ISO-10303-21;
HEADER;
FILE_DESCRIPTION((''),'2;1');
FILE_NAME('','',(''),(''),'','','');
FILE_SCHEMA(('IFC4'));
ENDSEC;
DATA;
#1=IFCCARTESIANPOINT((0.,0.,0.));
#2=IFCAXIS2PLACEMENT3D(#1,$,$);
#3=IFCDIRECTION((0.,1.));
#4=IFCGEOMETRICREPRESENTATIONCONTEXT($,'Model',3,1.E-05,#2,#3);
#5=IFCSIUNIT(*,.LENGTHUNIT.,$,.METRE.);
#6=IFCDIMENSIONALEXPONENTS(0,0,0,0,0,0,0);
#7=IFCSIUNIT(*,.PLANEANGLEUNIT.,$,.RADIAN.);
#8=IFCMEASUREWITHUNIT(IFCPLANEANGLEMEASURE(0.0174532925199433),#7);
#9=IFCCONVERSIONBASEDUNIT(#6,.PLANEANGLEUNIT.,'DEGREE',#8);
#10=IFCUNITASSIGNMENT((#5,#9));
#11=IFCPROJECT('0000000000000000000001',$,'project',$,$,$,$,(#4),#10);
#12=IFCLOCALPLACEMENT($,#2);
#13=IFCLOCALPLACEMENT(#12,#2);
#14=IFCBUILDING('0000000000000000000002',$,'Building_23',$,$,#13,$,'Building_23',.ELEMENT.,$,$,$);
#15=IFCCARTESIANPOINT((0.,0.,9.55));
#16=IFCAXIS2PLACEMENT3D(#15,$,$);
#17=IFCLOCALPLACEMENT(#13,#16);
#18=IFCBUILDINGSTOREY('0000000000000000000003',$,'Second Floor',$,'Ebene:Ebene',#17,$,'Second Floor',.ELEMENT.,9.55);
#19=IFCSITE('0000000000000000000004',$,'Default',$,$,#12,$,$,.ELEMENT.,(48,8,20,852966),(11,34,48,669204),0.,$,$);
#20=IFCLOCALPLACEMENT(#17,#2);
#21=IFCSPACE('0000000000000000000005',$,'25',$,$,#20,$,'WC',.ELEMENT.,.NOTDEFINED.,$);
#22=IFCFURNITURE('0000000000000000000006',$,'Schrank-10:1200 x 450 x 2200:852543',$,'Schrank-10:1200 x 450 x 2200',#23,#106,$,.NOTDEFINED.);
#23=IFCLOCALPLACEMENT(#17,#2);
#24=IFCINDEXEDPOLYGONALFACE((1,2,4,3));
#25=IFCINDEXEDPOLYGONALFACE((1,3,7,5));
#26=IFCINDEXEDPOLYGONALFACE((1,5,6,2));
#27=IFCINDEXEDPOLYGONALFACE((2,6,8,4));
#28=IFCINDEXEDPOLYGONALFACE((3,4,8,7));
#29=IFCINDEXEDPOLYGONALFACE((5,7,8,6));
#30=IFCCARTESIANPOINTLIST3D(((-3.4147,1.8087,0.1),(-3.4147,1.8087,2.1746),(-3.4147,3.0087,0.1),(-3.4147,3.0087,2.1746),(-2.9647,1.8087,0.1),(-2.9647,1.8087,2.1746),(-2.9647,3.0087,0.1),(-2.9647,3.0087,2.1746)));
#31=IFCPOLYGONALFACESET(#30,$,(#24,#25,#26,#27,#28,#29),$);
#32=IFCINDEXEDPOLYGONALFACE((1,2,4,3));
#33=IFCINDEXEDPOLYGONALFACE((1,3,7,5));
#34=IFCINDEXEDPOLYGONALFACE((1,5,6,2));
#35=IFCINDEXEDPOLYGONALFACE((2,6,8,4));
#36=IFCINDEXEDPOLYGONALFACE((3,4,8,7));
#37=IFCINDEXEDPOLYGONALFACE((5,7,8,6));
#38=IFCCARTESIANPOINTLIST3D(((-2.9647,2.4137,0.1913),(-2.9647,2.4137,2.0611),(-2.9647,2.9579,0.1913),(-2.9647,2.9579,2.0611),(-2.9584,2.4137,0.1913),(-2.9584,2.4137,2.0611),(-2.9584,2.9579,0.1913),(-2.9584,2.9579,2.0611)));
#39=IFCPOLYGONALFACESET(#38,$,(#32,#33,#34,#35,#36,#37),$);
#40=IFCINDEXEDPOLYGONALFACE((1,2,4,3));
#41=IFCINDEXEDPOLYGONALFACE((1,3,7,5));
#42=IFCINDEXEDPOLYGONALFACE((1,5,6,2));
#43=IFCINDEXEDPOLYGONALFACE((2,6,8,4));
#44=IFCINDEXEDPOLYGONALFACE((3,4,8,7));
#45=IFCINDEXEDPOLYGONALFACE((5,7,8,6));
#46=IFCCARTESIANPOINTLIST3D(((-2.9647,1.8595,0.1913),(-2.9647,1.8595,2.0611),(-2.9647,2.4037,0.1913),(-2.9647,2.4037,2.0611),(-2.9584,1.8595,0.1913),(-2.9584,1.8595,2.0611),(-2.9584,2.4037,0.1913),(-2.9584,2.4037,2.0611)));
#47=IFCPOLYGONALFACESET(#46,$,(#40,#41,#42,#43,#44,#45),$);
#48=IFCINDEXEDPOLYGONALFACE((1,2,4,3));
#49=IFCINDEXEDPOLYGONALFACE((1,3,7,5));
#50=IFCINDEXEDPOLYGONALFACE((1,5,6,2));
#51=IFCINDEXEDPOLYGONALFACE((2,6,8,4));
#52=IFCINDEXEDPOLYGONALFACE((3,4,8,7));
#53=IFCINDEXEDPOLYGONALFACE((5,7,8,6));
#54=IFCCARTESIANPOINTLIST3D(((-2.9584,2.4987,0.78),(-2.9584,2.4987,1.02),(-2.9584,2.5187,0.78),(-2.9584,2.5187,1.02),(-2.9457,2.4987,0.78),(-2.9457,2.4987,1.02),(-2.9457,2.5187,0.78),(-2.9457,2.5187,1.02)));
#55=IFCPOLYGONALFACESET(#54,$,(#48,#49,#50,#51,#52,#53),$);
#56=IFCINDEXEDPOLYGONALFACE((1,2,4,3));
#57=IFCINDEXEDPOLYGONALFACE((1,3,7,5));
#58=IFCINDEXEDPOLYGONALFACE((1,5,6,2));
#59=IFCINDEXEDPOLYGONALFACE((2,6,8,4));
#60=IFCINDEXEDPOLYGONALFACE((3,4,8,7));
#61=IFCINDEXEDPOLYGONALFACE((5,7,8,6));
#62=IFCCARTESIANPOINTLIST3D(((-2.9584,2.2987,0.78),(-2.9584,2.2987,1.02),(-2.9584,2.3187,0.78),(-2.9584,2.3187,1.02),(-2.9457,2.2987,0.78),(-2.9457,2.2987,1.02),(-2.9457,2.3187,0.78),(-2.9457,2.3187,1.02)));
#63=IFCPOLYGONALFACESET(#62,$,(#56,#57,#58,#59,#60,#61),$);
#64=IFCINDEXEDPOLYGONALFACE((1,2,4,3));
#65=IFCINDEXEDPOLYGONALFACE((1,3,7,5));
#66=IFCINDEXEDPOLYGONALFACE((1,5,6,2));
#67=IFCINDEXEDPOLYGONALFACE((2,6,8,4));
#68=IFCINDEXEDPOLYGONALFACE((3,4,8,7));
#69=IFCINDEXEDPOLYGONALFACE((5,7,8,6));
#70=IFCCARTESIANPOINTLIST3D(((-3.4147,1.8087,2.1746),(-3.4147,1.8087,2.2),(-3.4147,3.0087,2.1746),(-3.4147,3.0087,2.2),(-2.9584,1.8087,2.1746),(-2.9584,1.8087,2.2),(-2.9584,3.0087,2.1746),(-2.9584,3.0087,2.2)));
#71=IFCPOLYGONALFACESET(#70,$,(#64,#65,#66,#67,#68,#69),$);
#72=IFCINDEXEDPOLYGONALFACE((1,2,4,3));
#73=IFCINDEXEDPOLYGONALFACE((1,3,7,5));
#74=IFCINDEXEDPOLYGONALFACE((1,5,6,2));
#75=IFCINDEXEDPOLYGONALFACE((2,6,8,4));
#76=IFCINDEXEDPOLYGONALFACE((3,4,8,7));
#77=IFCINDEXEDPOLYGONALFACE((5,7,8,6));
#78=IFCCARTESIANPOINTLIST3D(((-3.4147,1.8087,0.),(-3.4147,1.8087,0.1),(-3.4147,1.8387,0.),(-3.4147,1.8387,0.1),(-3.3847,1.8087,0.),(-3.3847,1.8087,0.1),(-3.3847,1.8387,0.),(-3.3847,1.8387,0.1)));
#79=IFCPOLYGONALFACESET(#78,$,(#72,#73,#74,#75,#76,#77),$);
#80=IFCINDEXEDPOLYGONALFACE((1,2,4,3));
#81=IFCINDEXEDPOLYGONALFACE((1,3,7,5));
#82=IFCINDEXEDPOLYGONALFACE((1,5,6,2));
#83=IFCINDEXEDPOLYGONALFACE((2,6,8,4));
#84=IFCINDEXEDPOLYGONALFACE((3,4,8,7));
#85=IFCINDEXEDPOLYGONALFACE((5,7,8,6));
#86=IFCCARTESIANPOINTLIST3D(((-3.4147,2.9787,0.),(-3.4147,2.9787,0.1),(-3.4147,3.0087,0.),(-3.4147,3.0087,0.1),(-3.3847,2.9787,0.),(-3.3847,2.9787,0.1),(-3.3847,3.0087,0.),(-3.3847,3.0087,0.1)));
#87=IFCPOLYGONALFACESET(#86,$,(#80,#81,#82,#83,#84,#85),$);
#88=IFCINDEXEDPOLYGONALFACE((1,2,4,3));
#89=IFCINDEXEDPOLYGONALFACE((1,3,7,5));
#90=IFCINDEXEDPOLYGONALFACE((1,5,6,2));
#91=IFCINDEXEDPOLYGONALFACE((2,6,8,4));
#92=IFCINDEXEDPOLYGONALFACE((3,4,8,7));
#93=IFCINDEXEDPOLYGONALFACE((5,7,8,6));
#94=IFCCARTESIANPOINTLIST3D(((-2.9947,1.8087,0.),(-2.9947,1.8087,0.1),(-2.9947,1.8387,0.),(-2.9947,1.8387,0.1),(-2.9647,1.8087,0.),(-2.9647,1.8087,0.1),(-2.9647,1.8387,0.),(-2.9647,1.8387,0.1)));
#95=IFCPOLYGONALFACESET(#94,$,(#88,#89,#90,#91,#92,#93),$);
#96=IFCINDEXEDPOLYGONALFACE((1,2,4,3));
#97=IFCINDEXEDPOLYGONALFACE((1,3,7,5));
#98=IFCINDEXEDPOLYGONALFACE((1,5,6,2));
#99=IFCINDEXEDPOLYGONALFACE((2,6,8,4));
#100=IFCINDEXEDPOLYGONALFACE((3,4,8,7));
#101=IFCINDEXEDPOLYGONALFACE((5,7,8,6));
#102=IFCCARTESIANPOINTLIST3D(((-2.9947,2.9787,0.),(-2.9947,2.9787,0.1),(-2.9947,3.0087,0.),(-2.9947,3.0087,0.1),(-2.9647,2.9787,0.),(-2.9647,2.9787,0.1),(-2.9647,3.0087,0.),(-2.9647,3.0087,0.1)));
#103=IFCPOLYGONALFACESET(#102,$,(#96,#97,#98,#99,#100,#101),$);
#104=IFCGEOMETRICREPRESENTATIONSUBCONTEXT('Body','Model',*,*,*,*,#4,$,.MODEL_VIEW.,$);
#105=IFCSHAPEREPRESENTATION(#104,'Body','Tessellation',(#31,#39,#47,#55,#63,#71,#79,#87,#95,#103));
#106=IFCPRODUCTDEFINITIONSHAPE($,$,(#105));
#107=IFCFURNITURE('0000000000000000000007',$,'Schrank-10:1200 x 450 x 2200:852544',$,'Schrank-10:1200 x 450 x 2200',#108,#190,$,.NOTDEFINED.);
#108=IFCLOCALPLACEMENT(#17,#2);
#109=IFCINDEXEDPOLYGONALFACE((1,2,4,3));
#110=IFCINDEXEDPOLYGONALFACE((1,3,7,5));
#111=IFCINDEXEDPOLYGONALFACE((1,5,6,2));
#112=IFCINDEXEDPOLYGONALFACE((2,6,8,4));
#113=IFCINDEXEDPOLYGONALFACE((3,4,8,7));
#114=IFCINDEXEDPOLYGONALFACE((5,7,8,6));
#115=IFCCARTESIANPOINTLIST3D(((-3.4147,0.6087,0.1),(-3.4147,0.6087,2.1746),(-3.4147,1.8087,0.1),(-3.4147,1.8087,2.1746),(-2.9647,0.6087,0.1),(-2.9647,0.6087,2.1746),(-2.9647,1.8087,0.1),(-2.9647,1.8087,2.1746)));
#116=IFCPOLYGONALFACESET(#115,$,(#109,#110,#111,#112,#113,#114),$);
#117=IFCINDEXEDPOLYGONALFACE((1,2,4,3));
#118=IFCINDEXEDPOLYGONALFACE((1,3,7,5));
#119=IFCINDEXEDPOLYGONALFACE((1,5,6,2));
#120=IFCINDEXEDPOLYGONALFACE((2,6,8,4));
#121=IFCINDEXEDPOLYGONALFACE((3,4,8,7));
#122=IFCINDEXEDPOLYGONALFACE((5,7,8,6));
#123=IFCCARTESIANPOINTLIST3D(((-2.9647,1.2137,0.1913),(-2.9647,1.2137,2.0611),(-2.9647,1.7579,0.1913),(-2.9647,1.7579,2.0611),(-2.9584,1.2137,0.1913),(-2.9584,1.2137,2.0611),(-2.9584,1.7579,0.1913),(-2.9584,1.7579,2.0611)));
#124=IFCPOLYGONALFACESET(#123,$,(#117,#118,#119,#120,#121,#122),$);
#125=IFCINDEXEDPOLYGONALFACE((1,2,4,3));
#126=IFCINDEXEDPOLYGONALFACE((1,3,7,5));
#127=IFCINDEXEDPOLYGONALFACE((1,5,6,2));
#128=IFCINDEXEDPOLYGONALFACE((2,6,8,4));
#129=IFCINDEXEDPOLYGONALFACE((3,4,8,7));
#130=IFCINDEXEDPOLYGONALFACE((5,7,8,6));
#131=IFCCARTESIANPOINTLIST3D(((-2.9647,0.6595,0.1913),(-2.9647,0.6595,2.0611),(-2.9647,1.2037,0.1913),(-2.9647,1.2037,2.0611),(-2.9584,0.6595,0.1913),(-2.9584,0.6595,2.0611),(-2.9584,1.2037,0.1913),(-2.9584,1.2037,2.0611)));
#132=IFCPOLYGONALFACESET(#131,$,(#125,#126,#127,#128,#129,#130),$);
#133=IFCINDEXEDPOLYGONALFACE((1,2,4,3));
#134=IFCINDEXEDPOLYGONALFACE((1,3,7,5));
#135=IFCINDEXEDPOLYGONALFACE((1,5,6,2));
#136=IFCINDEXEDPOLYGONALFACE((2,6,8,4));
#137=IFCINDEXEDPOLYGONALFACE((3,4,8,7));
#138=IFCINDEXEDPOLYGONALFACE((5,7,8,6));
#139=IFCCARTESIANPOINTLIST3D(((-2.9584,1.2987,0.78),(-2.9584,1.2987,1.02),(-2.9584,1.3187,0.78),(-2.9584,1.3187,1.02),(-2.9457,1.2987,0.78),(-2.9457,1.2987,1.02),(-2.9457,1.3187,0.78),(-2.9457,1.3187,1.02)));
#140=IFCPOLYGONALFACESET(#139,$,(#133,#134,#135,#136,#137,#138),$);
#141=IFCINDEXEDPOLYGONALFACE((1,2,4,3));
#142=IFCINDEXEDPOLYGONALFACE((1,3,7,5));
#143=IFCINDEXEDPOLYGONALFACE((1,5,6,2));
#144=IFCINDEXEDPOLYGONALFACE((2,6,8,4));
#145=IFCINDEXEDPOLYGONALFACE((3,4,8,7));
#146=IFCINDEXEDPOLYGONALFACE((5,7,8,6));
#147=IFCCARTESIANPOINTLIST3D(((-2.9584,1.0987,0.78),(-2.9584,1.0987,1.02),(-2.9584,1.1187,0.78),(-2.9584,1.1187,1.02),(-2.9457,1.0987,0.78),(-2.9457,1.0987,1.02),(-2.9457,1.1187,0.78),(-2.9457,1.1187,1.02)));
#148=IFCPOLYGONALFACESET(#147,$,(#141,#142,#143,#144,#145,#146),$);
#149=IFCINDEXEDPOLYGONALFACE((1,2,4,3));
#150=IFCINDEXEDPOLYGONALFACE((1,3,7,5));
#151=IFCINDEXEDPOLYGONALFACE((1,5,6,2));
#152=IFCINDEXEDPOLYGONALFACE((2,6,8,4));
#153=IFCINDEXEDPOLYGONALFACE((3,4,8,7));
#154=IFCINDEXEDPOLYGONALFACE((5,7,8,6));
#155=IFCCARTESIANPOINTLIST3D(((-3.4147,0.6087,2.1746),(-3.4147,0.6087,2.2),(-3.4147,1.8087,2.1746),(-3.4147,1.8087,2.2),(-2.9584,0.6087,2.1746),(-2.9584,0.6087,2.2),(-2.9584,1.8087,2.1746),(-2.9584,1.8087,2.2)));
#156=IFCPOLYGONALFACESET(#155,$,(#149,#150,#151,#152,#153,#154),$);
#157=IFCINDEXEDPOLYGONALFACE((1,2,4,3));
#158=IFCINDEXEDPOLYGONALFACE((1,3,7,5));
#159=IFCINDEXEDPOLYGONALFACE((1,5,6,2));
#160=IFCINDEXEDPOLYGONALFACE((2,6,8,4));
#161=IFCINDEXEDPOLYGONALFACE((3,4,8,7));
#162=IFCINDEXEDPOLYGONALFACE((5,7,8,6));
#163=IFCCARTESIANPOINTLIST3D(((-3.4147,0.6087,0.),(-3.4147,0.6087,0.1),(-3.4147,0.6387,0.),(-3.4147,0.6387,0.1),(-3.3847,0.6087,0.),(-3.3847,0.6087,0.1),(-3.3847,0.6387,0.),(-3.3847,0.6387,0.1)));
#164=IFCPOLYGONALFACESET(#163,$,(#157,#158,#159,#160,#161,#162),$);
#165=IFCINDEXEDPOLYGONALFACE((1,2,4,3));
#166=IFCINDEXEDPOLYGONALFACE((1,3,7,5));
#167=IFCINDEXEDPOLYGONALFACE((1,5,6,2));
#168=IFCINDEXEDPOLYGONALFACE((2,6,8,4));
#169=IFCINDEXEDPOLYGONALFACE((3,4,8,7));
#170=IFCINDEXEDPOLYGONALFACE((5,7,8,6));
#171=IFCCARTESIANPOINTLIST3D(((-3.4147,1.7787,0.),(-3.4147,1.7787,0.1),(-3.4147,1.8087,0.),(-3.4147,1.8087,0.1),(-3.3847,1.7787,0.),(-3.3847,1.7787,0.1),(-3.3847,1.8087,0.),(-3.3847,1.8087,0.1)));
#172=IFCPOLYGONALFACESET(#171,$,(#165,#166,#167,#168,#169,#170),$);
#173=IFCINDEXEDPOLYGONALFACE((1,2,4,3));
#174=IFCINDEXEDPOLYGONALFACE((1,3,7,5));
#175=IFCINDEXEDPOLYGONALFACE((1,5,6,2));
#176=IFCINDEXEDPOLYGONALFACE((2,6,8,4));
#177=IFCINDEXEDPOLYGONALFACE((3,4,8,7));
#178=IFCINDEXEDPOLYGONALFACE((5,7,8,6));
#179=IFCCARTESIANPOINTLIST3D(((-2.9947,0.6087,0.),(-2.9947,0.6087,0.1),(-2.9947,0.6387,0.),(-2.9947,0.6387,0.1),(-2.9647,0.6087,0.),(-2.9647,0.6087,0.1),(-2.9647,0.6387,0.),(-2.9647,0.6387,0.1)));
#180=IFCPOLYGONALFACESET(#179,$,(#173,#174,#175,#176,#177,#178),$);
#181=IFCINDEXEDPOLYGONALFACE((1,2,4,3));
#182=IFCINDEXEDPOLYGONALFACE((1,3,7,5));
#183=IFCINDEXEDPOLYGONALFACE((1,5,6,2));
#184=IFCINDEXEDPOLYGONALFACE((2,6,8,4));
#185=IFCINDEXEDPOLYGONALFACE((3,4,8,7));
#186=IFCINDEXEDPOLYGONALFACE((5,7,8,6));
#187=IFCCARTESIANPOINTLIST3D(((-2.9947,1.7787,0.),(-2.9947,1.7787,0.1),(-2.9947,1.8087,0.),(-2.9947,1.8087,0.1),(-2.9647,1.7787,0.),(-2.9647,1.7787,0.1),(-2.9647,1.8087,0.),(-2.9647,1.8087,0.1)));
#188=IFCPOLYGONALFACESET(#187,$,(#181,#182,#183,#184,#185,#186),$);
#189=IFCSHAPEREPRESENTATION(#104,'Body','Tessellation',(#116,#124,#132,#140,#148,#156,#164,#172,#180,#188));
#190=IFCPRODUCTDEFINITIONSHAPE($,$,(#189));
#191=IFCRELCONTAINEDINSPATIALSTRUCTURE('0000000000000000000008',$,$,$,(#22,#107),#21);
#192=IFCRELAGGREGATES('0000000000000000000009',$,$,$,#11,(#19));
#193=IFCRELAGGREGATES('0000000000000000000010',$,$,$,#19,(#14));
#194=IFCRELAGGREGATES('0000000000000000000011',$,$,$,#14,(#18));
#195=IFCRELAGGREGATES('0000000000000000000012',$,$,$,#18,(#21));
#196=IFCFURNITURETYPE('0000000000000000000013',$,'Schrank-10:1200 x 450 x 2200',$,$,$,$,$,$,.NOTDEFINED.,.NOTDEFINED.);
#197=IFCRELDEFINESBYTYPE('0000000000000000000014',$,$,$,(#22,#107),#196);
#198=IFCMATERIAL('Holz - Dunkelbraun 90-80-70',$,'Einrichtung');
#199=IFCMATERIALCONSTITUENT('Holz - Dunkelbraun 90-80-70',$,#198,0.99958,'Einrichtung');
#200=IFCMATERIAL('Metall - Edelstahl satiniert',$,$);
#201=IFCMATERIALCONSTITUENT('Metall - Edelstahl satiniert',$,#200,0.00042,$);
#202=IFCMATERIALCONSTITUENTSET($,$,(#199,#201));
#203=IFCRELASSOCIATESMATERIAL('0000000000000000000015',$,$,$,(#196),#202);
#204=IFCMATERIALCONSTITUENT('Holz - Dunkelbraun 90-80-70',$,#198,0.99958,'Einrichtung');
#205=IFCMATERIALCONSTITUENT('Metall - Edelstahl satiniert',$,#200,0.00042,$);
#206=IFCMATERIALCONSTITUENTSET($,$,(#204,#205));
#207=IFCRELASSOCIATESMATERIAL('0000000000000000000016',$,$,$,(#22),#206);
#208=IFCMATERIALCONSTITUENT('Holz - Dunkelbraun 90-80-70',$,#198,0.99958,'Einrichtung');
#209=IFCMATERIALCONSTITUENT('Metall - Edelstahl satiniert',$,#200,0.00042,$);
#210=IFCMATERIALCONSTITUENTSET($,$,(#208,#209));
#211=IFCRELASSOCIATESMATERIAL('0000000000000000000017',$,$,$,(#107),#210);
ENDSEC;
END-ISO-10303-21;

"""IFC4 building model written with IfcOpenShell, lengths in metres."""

from ifc_helpers import new_model, entity, si_unit, converted_unit, direction, frame, origin, place, context, subcontext, project, spatial, indexed_curve, outline, extrude, source, transform, mapped, material, constituent, constituent_set, type_object, type_shapes, element, save


model = new_model("IFC4")

# Units and contexts
model_context = context("Model", 3, precision=1e-05, world=origin(), true_north=direction((0.0, 1.0)))
body_context = subcontext(model_context, "Body", "Model", "MODEL_VIEW")
ifc_project = project(units=[si_unit("LENGTHUNIT", "METRE"), converted_unit("PLANEANGLEUNIT", "DEGREE", entity("IfcPlaneAngleMeasure", 0.0174532925199433), si_unit("PLANEANGLEUNIT", "RADIAN"), dimensions=[0, 0, 0, 0, 0, 0, 0])], contexts=[model_context])

# Site, building, storey
site_placement = place(None, origin())
site = spatial("IfcSite", under=ifc_project, at=site_placement, Name="Default", CompositionType="ELEMENT", RefLatitude=(48, 8, 20, 852966), RefLongitude=(11, 34, 48, 669204), RefElevation=0.0)
building_placement = place(site_placement, origin())
building = spatial("IfcBuilding", under=site, at=building_placement, Name="Building_23", LongName="Building_23", CompositionType="ELEMENT")
storey_placement = place(building_placement, frame((0.0, 0.0, 9.55)))
storey = spatial("IfcBuildingStorey", under=building, at=storey_placement, Name="Second Floor", ObjectType="Ebene:Ebene", LongName="Second Floor", CompositionType="ELEMENT", Elevation=9.55)

# Shared definitions
ifc_material_1 = material(Name="Holz - Dunkelbraun 90-80-70", Category="Einrichtung")
ifc_material_2 = material(Name="Metall - Edelstahl satiniert")

# Shared definitions
ifc_constituent_1 = constituent(ifc_material_1, Name="Holz - Dunkelbraun 90-80-70", Category="Einrichtung", fraction=0.99958)
ifc_constituent_2 = constituent(ifc_material_2, Name="Metall - Edelstahl satiniert", fraction=0.00042)
ifc_constituent_set_1 = constituent_set(constituents=[ifc_constituent_1, ifc_constituent_2])
furniture_type_1 = type_object("IfcFurnitureType", Name="Schrank-10:1200 x 450 x 2200", AssemblyPlace="NOTDEFINED", PredefinedType="NOTDEFINED", material=ifc_constituent_set_1)
shared_shape_1 = source(origin(), body_context, "Body", "SweptSolid", [
    extrude(outline(indexed_curve([(-0.225, -0.6), (0.225, -0.6), (0.225, 0.6), (-0.225, 0.6), (-0.225, -0.6)], self_intersect=False)), frame((-0.2692, -0.3632, 0.1), z_axis=(0.0, 0.0, 1.0), x_axis=(0.0, 1.0, 0.0)), (0.0, 0.0, 1.0), 2.0746),
    extrude(outline(indexed_curve([(-0.0032, -0.2721), (0.0032, -0.2721), (0.0032, 0.2721), (-0.0032, 0.2721), (-0.0032, -0.2721)], self_intersect=False)), frame((0.0079, -0.5913, 0.1913), z_axis=(0.0, 0.0, 1.0), x_axis=(0.0, 1.0, 0.0)), (0.0, 0.0, 1.0), 1.8698),
    extrude(outline(indexed_curve([(-0.0032, -0.2721), (0.0032, -0.2721), (0.0032, 0.2721), (-0.0032, 0.2721), (-0.0032, -0.2721)], self_intersect=False)), frame((-0.5463, -0.5913, 0.1913), z_axis=(0.0, 0.0, 1.0), x_axis=(0.0, 1.0, 0.0)), (0.0, 0.0, 1.0), 1.8698),
    extrude(outline(indexed_curve([(-0.0063, -0.01), (0.0063, -0.01), (0.0063, 0.01), (-0.0063, 0.01), (-0.0063, -0.01)], self_intersect=False)), frame((-0.1692, -0.6009, 0.78), z_axis=(0.0, 0.0, 1.0), x_axis=(0.0, 1.0, 0.0)), (0.0, 0.0, 1.0), 0.24),
    extrude(outline(indexed_curve([(-0.0063, -0.01), (0.0063, -0.01), (0.0063, 0.01), (-0.0063, 0.01), (-0.0063, -0.01)], self_intersect=False)), frame((-0.3692, -0.6009, 0.78), z_axis=(0.0, 0.0, 1.0), x_axis=(0.0, 1.0, 0.0)), (0.0, 0.0, 1.0), 0.24),
    extrude(outline(indexed_curve([(-0.6, -0.2282), (0.6, -0.2282), (0.6, 0.2282), (-0.6, 0.2282), (-0.6, -0.2282)], self_intersect=False)), frame((-0.2692, -0.3663, 2.1746), z_axis=(0.0, 0.0, 1.0), x_axis=(-1.0, 0.0, 0.0)), (0.0, 0.0, 1.0), 0.0254),
    extrude(outline(indexed_curve([(-0.015, -0.015), (0.015, -0.015), (0.015, 0.015), (-0.015, 0.015), (-0.015, -0.015)], self_intersect=False)), frame((-0.8542, -0.1532, 0.0), z_axis=(0.0, 0.0, 1.0), x_axis=(-1.0, 0.0, 0.0)), (0.0, 0.0, 1.0), 0.1),
    extrude(outline(indexed_curve([(-0.015, -0.015), (0.015, -0.015), (0.015, 0.015), (-0.015, 0.015), (-0.015, -0.015)], self_intersect=False)), frame((0.3158, -0.1532, 0.0), z_axis=(0.0, 0.0, 1.0), x_axis=(0.0, -1.0, 0.0)), (0.0, 0.0, 1.0), 0.1),
    extrude(outline(indexed_curve([(-0.015, -0.015), (0.015, -0.015), (0.015, 0.015), (-0.015, 0.015), (-0.015, -0.015)], self_intersect=False)), frame((-0.8542, -0.5732, 0.0), z_axis=(0.0, 0.0, 1.0), x_axis=(0.0, 1.0, 0.0)), (0.0, 0.0, 1.0), 0.1),
    extrude(outline(indexed_curve([(-0.015, -0.015), (0.015, -0.015), (0.015, 0.015), (-0.015, 0.015), (-0.015, -0.015)], self_intersect=False)), frame((0.3158, -0.5732, 0.0)), (0.0, 0.0, 1.0), 0.1),
])
type_shapes(furniture_type_1, [shared_shape_1])

# Shared definitions
space_1_placement = place(storey_placement, origin())
space_1 = spatial("IfcSpace", under=storey, at=space_1_placement, Name="25", LongName="WC", CompositionType="ELEMENT", PredefinedType="NOTDEFINED")

# Furniture
ifc_constituent_3 = constituent(ifc_material_1, Name="Holz - Dunkelbraun 90-80-70", Category="Einrichtung", fraction=0.99958)
ifc_constituent_4 = constituent(ifc_material_2, Name="Metall - Edelstahl satiniert", fraction=0.00042)
ifc_constituent_set_2 = constituent_set(constituents=[ifc_constituent_3, ifc_constituent_4])
furniture_1_placement = place(space_1_placement, frame((-3.5529, 2.6779, 0.0), z_axis=(0.0, 0.0, 1.0), x_axis=(0.0, 1.0, 0.0)))
element("IfcFurniture", 1, at=furniture_1_placement, inside=space_1, type_object=furniture_type_1, material=ifc_constituent_set_2, Name="Schrank-10:1200 x 450 x 2200:852543", ObjectType="Schrank-10:1200 x 450 x 2200", PredefinedType="NOTDEFINED", context=body_context, shape_type="MappedRepresentation", body=[
    mapped(shared_shape_1, transform((0.0, 0.0, 0.0), scale=1.0)),
])
ifc_constituent_5 = constituent(ifc_material_1, Name="Holz - Dunkelbraun 90-80-70", Category="Einrichtung", fraction=0.99958)
ifc_constituent_6 = constituent(ifc_material_2, Name="Metall - Edelstahl satiniert", fraction=0.00042)
ifc_constituent_set_3 = constituent_set(constituents=[ifc_constituent_5, ifc_constituent_6])
furniture_2_placement = place(space_1_placement, frame((-3.5529, 1.4779, 0.0), z_axis=(0.0, 0.0, 1.0), x_axis=(0.0, 1.0, 0.0)))
element("IfcFurniture", 2, at=furniture_2_placement, inside=space_1, type_object=furniture_type_1, material=ifc_constituent_set_3, Name="Schrank-10:1200 x 450 x 2200:852544", ObjectType="Schrank-10:1200 x 450 x 2200", PredefinedType="NOTDEFINED", context=body_context, shape_type="MappedRepresentation", body=[
    mapped(shared_shape_1, transform((0.0, 0.0, 0.0), scale=1.0)),
])

save(model, "model.ifc")
